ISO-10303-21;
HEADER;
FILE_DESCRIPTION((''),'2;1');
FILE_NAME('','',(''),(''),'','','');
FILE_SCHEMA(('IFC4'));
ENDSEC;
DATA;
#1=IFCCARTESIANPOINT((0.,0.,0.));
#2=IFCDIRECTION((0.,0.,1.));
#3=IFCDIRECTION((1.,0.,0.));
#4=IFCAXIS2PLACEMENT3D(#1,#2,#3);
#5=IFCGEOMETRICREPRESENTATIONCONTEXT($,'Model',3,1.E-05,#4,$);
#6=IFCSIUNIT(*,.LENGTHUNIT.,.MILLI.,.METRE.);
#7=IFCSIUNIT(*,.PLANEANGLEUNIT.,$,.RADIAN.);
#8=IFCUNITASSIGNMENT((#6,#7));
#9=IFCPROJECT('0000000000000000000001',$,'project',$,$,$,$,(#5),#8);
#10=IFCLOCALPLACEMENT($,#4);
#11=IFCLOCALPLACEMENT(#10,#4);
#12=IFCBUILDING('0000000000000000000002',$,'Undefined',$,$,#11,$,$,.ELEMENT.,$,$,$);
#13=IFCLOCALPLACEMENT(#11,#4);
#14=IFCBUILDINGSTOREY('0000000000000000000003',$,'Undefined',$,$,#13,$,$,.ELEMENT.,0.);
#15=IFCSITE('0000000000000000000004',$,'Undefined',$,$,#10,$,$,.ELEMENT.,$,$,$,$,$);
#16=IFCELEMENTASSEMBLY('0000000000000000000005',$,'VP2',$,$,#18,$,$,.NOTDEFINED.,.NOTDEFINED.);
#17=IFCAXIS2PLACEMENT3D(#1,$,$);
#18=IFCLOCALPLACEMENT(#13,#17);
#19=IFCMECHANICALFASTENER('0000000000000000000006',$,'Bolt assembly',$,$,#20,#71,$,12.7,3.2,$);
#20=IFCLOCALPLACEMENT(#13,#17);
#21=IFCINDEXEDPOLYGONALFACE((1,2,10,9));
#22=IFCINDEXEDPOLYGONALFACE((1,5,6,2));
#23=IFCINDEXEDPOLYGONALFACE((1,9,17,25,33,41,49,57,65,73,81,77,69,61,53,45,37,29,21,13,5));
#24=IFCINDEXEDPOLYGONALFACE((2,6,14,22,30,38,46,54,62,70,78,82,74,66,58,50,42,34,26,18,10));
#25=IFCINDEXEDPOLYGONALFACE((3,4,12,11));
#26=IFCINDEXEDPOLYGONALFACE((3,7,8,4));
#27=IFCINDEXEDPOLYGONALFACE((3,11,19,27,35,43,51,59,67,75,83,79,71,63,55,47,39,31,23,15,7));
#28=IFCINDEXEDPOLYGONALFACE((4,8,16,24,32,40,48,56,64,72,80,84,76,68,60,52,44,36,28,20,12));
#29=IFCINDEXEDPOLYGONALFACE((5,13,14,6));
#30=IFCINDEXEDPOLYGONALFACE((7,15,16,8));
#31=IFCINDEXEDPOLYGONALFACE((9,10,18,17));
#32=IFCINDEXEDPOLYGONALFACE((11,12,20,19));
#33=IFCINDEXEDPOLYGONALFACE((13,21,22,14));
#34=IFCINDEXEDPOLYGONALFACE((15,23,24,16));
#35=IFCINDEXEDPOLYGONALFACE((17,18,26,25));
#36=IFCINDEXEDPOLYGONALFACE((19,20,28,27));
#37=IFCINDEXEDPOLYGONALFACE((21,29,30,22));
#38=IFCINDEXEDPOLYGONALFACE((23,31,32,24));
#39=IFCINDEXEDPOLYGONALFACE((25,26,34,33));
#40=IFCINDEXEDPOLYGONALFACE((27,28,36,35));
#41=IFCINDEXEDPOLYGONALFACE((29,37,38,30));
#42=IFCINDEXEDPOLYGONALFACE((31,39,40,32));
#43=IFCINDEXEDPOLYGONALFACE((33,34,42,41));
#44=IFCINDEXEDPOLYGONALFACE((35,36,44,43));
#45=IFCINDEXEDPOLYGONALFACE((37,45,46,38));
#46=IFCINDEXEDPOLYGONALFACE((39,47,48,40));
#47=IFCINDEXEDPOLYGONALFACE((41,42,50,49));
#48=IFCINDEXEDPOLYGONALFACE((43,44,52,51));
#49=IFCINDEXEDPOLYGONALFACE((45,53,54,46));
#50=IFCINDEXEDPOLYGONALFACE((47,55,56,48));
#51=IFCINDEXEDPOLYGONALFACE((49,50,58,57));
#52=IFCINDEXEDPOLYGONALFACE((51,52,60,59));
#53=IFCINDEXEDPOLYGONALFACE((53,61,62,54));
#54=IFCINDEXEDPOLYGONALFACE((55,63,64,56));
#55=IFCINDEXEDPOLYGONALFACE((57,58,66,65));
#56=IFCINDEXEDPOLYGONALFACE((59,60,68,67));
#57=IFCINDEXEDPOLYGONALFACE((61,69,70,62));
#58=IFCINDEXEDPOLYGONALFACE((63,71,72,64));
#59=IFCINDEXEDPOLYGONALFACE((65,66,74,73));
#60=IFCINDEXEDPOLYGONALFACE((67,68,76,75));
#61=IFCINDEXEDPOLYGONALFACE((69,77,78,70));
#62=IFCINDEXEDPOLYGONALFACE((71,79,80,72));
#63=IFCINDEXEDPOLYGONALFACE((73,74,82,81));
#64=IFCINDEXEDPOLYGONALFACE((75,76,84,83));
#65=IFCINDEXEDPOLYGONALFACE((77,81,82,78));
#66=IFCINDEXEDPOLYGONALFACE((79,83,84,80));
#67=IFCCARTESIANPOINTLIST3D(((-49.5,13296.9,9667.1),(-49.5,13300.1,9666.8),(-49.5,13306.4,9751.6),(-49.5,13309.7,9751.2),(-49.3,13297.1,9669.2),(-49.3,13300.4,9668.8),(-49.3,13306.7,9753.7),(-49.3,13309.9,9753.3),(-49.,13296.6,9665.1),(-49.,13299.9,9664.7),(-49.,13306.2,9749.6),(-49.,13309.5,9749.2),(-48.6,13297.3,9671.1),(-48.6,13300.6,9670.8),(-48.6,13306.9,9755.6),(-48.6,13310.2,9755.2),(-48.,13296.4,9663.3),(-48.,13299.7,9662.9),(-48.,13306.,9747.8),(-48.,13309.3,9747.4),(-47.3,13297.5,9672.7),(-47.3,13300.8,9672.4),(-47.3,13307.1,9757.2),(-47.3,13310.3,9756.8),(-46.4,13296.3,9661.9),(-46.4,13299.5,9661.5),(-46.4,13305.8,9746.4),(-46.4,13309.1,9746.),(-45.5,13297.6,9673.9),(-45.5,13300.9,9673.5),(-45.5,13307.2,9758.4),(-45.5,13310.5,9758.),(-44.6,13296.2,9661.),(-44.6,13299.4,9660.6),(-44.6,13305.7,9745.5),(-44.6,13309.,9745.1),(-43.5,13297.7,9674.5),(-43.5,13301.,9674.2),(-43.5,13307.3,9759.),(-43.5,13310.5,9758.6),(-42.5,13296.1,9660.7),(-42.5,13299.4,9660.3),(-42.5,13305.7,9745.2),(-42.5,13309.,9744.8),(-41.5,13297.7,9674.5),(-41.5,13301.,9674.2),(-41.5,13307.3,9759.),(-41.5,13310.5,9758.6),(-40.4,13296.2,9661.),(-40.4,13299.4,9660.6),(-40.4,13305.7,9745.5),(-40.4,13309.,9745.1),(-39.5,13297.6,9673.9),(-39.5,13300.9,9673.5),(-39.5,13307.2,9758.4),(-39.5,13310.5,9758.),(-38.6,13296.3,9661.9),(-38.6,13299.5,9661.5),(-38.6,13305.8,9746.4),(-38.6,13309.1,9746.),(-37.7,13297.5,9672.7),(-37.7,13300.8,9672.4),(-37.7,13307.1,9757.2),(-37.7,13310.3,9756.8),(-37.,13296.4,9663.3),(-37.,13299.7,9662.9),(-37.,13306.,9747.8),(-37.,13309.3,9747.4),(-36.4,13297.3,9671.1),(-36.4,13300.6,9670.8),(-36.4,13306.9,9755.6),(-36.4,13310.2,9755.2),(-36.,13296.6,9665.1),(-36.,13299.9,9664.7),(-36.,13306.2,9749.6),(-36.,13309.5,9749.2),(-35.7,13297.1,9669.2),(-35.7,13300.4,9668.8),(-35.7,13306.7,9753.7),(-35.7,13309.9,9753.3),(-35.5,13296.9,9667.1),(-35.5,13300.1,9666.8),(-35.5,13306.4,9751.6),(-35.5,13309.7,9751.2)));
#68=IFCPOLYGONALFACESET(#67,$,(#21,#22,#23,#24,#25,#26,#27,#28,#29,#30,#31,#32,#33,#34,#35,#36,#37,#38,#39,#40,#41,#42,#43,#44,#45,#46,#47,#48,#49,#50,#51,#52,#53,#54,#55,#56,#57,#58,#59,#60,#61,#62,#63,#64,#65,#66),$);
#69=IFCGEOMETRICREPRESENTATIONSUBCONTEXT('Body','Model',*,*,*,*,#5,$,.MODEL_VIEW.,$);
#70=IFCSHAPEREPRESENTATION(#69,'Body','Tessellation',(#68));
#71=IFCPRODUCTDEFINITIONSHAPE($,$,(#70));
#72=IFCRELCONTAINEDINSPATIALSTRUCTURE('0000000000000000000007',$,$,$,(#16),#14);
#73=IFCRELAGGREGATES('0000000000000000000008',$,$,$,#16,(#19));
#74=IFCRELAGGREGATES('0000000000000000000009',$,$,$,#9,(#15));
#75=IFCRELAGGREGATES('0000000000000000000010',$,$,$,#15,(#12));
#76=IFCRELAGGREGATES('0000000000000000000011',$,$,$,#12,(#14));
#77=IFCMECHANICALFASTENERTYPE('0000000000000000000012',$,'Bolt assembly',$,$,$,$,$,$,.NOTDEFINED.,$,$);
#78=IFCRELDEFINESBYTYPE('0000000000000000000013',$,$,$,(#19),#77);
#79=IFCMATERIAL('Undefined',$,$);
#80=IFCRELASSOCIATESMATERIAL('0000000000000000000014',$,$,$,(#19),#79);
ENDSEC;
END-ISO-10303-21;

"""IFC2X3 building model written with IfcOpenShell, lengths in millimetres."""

from ifc_helpers import new_model, si_unit, frame, origin_with_axes, origin_2d_with_axis, place, context, subcontext, project, spatial, circle, extrude, source, transform, mapped, material, type_object, element, aggregate, save


model = new_model("IFC2X3")

# Units and contexts
model_context = context("Model", 3, precision=1e-05, world=origin_with_axes())
body_context = subcontext(model_context, "Body", "Model", "MODEL_VIEW")
ifc_project = project(units=[si_unit("LENGTHUNIT", "METRE", prefix="MILLI"), si_unit("PLANEANGLEUNIT", "RADIAN")], contexts=[model_context])

# Site, building, storey
site_placement = place(None, origin_with_axes())
site = spatial("IfcSite", under=ifc_project, at=site_placement, Name="Undefined", CompositionType="ELEMENT")
building_placement = place(site_placement, origin_with_axes())
building = spatial("IfcBuilding", under=site, at=building_placement, Name="Undefined", CompositionType="ELEMENT")
storey_placement = place(building_placement, origin_with_axes())
storey = spatial("IfcBuildingStorey", under=building, at=storey_placement, Name="Undefined", CompositionType="ELEMENT", Elevation=0.0)

# Element assembly
assembly_1_placement = place(storey_placement, origin_with_axes())
assembly_1 = element("IfcElementAssembly", 1, at=assembly_1_placement, inside=storey, Name="VP2", AssemblyPlace="NOTDEFINED", PredefinedType="NOTDEFINED")

# Shared definitions
ifc_material_1 = material(Name="Undefined")
mechanical_fastener_type = type_object("IfcMechanicalFastenerType", Name="Bolt assembly")

# Mechanical fastener
shared_shape_1 = source(origin_with_axes(), body_context, "Body", "SweptSolid", [
    extrude(circle(Radius=7.0, at=origin_2d_with_axis()), frame((0.0, -3.2, 0.0), z_axis=(0.0, 1.0, 0.0), x_axis=(1.0, 0.0, 0.0)), (0.0, 0.0, 1.0), 3.3),
])
mechanical_fastener_1_placement = place(assembly_1_placement, frame((-42.5, 13309.7, 9751.7), z_axis=(1.0, 0.0, 0.0), x_axis=(0.0, -0.112644, -0.993635)))
mechanical_fastener_1 = element("IfcMechanicalFastener", 2, at=mechanical_fastener_1_placement, type_object=mechanical_fastener_type, material=ifc_material_1, Name="Bolt assembly", NominalDiameter=12.7, NominalLength=3.2, context=body_context, shape_type="MappedRepresentation", body=[
    mapped(shared_shape_1, transform((0.0, 0.0, 0.0))),
    mapped(shared_shape_1, transform((85.0, 0.0, 0.0))),
])
aggregate(assembly_1, [mechanical_fastener_1])

save(model, "model.ifc")
